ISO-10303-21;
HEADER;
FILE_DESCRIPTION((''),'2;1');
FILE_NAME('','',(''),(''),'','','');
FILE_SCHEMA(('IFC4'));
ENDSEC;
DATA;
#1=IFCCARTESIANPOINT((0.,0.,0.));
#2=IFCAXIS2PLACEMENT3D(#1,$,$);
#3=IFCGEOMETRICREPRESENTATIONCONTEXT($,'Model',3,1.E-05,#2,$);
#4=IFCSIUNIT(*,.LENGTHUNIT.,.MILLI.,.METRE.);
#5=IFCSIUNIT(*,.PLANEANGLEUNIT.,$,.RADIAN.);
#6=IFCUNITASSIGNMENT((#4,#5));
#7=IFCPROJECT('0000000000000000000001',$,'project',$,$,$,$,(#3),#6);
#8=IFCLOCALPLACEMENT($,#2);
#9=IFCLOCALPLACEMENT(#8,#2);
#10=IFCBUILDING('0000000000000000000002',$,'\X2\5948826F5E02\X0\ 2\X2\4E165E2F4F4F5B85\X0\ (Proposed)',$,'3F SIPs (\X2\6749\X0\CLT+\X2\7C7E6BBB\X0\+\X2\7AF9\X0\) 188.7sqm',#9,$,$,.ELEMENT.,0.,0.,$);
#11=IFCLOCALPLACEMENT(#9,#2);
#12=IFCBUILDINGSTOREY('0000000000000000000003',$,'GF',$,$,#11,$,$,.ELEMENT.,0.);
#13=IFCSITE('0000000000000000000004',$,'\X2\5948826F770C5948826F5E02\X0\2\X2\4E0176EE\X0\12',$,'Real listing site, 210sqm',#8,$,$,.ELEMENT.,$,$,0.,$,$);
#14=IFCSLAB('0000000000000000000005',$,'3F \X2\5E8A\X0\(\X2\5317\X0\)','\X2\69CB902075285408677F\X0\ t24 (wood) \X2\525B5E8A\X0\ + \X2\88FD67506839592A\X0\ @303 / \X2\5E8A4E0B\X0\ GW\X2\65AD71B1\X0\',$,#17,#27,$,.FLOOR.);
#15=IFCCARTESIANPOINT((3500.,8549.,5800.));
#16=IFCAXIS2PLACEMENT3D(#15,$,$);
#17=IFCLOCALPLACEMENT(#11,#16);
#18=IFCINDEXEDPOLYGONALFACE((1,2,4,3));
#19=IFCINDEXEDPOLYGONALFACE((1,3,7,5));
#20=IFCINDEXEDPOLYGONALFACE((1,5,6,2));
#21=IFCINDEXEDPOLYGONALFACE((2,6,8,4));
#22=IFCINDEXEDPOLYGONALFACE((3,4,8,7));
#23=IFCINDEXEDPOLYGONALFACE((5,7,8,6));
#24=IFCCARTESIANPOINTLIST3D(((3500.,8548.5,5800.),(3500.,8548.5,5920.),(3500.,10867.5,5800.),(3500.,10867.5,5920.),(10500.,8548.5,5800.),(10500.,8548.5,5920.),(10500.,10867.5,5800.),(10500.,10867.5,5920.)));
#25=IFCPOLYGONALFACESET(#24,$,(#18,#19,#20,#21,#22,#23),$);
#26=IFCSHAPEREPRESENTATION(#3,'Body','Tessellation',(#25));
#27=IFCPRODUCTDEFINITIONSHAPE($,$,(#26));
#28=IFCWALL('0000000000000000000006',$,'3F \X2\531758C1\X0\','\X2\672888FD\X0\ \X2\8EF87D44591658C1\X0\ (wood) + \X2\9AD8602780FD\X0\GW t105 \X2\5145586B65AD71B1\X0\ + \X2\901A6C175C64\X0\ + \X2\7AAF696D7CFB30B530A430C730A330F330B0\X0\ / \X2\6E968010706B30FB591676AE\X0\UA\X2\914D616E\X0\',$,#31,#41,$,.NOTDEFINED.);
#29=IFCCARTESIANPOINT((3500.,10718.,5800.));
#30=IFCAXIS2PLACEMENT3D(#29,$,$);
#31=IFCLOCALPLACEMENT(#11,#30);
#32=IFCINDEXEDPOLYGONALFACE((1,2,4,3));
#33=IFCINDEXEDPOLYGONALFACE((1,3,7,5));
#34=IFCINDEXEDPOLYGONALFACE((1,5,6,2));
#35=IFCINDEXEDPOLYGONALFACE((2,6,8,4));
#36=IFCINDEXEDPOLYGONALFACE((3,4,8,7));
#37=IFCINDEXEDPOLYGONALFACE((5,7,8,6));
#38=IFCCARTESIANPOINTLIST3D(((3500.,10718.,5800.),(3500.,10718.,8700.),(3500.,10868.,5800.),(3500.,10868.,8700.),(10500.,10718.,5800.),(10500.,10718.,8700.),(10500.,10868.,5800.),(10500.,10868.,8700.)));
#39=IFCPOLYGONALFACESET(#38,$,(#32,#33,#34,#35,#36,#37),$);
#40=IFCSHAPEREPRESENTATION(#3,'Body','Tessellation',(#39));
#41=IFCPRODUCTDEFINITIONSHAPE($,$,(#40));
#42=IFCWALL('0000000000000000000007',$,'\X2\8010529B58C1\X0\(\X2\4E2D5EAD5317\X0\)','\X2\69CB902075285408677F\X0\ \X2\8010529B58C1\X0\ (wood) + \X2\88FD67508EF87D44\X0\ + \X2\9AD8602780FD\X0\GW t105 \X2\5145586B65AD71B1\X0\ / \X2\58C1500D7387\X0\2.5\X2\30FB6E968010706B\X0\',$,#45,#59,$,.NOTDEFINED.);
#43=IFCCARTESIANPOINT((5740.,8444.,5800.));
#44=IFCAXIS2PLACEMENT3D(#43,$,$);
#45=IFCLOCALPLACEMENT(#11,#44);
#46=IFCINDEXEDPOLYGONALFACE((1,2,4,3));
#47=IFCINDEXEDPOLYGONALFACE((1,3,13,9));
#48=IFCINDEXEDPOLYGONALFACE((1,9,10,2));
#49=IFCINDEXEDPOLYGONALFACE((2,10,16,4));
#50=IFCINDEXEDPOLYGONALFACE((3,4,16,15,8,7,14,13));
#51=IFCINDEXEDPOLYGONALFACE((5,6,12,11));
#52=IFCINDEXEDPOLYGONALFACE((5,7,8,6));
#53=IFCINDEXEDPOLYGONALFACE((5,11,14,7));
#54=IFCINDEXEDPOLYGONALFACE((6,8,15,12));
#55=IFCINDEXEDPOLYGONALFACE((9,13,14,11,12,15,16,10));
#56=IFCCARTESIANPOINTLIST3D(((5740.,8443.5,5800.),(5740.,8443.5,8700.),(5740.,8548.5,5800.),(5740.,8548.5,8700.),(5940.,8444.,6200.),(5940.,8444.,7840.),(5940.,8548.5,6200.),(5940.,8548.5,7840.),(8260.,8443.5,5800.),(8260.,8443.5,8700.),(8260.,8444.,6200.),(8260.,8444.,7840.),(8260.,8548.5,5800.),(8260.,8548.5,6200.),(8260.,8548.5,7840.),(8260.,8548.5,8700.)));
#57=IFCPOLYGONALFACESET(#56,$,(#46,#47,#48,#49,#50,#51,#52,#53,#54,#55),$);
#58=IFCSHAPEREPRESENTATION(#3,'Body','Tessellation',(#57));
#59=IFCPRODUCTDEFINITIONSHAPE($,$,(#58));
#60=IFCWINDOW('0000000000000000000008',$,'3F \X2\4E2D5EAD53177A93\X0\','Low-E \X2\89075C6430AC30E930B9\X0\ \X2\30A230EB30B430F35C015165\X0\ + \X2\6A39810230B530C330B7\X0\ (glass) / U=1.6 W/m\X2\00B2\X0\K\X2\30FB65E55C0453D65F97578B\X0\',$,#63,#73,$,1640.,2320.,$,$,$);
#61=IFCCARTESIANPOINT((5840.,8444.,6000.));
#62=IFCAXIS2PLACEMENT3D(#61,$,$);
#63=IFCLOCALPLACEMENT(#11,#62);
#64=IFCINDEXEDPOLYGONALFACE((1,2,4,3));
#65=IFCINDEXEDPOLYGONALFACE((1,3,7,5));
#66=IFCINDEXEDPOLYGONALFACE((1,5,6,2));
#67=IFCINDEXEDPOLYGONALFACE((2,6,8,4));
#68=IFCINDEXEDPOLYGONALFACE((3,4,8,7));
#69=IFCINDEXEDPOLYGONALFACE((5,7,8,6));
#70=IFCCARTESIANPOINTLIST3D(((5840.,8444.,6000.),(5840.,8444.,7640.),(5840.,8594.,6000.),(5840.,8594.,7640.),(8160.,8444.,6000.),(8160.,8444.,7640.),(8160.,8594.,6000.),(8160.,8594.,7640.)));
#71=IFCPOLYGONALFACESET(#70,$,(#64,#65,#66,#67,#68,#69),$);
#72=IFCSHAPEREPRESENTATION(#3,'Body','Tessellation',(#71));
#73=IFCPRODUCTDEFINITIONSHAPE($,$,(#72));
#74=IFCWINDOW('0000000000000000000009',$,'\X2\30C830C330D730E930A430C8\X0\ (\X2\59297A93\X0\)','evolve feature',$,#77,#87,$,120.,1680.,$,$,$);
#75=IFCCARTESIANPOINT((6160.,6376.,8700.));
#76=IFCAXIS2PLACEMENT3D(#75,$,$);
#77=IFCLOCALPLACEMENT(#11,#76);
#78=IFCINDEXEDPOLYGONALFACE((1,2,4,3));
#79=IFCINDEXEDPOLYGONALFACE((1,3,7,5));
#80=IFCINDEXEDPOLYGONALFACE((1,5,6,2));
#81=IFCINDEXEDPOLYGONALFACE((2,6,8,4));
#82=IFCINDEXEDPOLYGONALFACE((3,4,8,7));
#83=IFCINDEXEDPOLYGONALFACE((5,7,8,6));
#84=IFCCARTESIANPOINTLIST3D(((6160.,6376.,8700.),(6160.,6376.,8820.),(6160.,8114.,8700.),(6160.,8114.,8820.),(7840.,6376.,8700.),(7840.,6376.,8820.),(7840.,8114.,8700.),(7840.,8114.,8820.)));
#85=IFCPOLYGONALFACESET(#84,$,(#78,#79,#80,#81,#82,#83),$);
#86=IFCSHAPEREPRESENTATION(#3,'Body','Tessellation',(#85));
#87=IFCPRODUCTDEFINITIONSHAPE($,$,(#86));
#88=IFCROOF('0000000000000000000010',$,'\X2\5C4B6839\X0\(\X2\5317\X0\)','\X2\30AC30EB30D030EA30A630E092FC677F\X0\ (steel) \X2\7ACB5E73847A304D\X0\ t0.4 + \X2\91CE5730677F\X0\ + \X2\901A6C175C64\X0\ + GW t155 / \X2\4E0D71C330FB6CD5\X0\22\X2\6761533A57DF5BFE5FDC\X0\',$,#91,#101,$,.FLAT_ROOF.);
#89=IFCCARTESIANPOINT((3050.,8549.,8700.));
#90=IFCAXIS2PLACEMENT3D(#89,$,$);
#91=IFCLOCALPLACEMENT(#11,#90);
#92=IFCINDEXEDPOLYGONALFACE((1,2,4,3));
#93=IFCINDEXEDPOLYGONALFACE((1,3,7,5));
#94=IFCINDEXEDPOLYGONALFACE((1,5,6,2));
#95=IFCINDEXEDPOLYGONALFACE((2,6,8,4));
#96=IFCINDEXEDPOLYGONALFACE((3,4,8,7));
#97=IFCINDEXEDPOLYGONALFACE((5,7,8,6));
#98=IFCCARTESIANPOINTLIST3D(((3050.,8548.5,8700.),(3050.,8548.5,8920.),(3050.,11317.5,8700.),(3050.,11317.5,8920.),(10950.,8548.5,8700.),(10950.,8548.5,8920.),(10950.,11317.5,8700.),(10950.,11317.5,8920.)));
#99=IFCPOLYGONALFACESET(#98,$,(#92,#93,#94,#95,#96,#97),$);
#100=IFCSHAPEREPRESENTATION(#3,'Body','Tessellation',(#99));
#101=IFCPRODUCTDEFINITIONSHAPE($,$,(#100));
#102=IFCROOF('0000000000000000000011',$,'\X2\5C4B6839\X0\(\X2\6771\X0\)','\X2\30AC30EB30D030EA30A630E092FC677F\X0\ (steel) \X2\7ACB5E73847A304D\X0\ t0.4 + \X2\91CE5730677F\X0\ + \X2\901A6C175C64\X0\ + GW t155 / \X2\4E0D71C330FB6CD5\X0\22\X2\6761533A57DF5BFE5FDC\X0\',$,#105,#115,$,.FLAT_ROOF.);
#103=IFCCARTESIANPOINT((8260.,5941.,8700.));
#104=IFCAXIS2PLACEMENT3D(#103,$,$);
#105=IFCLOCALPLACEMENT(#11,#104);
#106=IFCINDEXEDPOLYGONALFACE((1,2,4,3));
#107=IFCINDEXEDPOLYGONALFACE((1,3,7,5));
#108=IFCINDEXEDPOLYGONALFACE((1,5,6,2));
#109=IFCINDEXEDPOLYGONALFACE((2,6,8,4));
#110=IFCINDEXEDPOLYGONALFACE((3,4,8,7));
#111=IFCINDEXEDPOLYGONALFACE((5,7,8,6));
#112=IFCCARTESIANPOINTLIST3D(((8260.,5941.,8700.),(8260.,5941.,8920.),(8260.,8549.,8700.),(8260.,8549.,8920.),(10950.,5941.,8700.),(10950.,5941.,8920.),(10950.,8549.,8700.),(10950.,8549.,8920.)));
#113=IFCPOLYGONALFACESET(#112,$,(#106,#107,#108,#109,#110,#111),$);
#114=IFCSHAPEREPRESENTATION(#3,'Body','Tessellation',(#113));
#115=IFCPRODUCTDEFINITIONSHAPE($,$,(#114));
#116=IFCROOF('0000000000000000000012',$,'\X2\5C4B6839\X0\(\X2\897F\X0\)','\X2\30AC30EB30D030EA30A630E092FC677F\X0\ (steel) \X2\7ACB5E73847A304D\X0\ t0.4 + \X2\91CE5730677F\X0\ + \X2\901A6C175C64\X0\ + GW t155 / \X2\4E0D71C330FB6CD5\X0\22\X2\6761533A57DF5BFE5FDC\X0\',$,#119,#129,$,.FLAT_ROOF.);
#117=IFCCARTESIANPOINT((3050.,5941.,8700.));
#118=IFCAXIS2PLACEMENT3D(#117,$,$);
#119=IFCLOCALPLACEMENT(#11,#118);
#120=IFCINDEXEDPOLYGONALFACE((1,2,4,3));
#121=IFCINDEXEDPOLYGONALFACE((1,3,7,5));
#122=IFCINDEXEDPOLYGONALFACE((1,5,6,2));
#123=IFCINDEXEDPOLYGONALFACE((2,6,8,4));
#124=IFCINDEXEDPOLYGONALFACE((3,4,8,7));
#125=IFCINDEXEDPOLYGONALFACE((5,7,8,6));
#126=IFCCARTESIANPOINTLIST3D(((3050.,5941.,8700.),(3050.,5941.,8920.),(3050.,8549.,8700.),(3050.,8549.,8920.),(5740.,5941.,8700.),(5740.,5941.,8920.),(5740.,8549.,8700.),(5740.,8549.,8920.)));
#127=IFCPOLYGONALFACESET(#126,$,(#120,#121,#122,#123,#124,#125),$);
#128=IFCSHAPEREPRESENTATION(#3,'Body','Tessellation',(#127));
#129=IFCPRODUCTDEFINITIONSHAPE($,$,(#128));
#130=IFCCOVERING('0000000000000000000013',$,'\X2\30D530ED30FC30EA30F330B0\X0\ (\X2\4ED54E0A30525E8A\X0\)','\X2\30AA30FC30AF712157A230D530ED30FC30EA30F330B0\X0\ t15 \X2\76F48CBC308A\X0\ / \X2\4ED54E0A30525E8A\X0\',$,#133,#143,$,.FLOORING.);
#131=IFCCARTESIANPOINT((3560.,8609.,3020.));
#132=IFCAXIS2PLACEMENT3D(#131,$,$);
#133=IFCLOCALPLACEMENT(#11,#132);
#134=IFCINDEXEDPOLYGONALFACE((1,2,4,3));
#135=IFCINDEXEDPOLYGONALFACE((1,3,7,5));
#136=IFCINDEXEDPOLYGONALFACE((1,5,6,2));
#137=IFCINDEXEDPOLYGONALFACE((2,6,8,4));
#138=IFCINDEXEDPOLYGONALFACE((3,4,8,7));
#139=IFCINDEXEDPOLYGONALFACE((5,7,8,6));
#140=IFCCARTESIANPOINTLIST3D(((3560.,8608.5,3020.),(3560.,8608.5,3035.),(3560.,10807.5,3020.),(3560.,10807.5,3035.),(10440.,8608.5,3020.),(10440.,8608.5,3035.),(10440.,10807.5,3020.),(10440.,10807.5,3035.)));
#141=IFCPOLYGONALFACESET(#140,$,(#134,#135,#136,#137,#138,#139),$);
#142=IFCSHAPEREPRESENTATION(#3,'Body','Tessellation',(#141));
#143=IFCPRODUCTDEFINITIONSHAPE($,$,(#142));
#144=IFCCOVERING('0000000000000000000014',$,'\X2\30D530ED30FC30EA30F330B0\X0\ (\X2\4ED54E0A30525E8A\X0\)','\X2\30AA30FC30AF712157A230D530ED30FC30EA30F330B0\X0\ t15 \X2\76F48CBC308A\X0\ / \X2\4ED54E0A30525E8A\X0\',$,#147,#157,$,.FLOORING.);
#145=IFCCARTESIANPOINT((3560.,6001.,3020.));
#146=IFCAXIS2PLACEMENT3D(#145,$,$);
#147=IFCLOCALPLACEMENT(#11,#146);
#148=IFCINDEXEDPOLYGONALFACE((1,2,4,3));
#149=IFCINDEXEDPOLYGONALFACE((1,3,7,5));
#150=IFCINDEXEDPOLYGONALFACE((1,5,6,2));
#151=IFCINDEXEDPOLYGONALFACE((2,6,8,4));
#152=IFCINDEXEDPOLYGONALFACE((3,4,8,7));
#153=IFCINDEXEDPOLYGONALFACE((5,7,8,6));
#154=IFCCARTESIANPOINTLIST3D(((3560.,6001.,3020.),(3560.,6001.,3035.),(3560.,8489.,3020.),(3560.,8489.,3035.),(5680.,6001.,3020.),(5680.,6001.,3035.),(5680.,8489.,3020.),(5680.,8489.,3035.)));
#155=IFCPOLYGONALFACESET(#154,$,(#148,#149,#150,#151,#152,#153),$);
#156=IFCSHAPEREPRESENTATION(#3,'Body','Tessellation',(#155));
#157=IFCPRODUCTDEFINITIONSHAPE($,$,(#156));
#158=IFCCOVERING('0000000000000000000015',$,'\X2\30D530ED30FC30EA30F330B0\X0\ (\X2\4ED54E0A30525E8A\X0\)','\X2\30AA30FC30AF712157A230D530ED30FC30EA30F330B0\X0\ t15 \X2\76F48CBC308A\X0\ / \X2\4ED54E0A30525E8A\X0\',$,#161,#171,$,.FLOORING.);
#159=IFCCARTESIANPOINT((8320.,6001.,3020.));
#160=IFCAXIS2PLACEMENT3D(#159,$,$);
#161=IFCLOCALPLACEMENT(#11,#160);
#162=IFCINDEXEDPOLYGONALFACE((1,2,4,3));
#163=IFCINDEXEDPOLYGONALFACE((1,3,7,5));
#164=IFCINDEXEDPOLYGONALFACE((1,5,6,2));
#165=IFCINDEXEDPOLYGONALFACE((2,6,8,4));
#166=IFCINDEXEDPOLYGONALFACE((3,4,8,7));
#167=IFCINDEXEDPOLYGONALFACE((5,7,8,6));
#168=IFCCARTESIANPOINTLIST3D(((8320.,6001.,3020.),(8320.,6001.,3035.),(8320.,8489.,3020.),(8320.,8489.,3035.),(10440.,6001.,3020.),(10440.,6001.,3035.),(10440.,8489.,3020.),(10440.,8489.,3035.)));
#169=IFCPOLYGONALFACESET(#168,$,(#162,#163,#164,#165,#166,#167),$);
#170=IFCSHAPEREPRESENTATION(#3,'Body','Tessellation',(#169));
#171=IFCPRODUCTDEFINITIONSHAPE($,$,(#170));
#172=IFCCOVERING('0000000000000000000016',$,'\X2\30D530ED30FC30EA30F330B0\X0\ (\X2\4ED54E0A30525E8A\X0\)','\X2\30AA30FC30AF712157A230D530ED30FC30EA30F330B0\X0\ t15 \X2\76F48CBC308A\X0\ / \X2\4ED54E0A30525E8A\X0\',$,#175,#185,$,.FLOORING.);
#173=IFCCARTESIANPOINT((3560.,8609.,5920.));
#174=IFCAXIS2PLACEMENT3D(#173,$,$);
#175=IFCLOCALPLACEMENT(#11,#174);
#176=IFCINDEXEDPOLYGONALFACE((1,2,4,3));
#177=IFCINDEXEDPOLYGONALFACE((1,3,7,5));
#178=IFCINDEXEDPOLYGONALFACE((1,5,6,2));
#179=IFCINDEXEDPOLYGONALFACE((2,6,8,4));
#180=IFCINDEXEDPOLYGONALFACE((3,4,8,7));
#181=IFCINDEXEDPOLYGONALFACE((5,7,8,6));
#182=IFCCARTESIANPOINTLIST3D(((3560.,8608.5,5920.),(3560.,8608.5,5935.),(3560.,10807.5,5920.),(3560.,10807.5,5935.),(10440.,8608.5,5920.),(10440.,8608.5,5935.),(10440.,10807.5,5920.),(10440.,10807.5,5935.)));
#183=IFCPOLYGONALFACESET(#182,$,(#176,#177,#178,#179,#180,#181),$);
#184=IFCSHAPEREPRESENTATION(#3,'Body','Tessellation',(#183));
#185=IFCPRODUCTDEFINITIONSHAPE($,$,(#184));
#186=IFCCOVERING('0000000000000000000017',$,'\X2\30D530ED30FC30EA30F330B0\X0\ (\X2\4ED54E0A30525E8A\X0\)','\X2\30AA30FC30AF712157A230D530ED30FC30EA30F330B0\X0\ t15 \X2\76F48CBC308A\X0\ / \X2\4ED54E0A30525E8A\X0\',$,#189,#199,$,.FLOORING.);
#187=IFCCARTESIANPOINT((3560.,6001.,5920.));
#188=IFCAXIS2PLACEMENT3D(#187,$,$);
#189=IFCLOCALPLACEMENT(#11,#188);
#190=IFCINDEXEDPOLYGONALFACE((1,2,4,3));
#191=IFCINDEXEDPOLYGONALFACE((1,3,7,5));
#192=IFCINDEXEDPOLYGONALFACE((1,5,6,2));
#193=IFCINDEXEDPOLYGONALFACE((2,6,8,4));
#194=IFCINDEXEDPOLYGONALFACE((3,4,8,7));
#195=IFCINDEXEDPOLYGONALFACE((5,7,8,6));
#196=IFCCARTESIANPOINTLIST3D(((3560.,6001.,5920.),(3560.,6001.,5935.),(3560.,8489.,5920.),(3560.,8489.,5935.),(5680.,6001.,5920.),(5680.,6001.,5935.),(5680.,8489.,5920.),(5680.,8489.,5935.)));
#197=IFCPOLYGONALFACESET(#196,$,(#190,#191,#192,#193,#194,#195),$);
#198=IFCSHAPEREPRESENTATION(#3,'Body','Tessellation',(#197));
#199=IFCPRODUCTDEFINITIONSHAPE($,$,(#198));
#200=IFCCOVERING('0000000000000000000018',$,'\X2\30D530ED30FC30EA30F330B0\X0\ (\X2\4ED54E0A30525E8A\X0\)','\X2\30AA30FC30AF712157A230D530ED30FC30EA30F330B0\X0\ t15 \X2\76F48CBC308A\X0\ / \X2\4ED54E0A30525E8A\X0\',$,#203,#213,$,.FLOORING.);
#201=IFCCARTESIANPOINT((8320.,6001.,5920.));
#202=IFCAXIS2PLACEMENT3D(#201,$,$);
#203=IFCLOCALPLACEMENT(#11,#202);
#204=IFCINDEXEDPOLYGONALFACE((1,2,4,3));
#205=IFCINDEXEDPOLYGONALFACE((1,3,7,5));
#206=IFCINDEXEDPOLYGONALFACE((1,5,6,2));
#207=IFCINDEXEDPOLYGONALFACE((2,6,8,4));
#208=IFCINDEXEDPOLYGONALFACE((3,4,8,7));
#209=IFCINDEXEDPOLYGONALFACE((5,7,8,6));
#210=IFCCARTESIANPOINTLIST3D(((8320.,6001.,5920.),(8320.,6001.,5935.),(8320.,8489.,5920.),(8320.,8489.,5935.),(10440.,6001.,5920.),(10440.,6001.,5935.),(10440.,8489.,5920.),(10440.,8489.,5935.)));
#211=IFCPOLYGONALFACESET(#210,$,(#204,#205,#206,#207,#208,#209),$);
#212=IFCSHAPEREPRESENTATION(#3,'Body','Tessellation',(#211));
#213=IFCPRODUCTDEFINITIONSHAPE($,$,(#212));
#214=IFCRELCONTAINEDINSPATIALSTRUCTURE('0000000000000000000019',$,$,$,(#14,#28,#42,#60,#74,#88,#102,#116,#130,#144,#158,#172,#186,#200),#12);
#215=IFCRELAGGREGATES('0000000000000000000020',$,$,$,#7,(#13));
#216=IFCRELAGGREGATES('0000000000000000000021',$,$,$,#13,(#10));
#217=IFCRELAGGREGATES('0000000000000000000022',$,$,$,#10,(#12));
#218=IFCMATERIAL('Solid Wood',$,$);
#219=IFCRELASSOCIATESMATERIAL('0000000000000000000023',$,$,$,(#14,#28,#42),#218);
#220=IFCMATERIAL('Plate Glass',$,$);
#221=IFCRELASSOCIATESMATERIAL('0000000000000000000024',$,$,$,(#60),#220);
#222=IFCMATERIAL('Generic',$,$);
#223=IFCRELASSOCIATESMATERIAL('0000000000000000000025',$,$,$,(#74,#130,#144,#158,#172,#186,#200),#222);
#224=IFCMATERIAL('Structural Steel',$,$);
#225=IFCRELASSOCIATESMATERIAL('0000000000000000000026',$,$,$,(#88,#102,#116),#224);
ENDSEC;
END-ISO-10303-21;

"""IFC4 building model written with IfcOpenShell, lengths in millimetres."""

from ifc_helpers import new_model, si_unit, frame, frame_2d, origin, place, context, project, spatial, rectangle, extrude, material, element, fill, save


model = new_model("IFC4")

# Units and contexts
model_context = context("Model", 3, precision=1e-05, world=origin())
ifc_project = project(units=[si_unit("LENGTHUNIT", "METRE", prefix="MILLI"), si_unit("PLANEANGLEUNIT", "RADIAN")], contexts=[model_context])

# Site, building, storey
site_placement = place(None, origin())
site = spatial("IfcSite", under=ifc_project, at=site_placement, Name="奈良県奈良市2丁目12", ObjectType="Real listing site, 210sqm", CompositionType="ELEMENT", RefElevation=0.0)
building_placement = place(site_placement, origin())
building = spatial("IfcBuilding", under=site, at=building_placement, Name="奈良市 2世帯住宅 (Proposed)", ObjectType="3F SIPs (杉CLT+籾殻+竹) 188.7sqm", CompositionType="ELEMENT", ElevationOfRefHeight=0.0, ElevationOfTerrain=0.0)
storey_placement = place(building_placement, origin())
storey = spatial("IfcBuildingStorey", under=building, at=storey_placement, Name="GF", CompositionType="ELEMENT", Elevation=0.0)

# Slab
ifc_material_1 = material(Name="Solid Wood")
slab_placement = place(storey_placement, frame((3500.0, 8549.0, 5800.0)))
element("IfcSlab", 1, at=slab_placement, inside=storey, material=ifc_material_1, Name="3F 床(北)", Description="構造用合板 t24 (wood) 剛床 + 製材根太 @303 / 床下 GW断熱", PredefinedType="FLOOR", context=model_context, shape_type="SweptSolid", body=[
    extrude(rectangle(XDim=7000.0, YDim=2319.0, at=frame_2d((3500.0, 1159.0))), frame((3500.0, 8549.0, 5800.0)), (0.0, 0.0, 1.0), 120.0),
])

# Wall
wall_1_placement = place(storey_placement, frame((3500.0, 10718.0, 5800.0)))
element("IfcWall", 2, at=wall_1_placement, inside=storey, material=ifc_material_1, Name="3F 北壁", Description="木製 軸組外壁 (wood) + 高性能GW t105 充填断熱 + 通気層 + 窯業系サイディング / 準耐火・外皮UA配慮", PredefinedType="NOTDEFINED", context=model_context, shape_type="SweptSolid", body=[
    extrude(rectangle(XDim=7000.0, YDim=150.0, at=frame_2d((3500.0, 75.0))), frame((3500.0, 10718.0, 5800.0)), (0.0, 0.0, 1.0), 2900.0),
])

# Wall, opening, window
wall_2_placement = place(storey_placement, frame((5740.0, 8444.0, 5800.0)))
wall_2 = element("IfcWall", 3, at=wall_2_placement, inside=storey, material=ifc_material_1, Name="耐力壁(中庭北)", Description="構造用合板 耐力壁 (wood) + 製材軸組 + 高性能GW t105 充填断熱 / 壁倍率2.5・準耐火", PredefinedType="NOTDEFINED", context=model_context, shape_type="SweptSolid", body=[
    extrude(rectangle(XDim=2520.0, YDim=105.0, at=frame_2d((1260.0, 52.0))), frame((5740.0, 8444.0, 5800.0)), (0.0, 0.0, 1.0), 2900.0),
])
opening_placement = place(storey_placement, frame((5840.0, 8444.0, 6000.0)))
opening = element("IfcOpeningElement", 4, at=opening_placement, cuts=wall_2, PredefinedType="NOTDEFINED", context=model_context, shape_type="SweptSolid", body=[
    extrude(rectangle(XDim=2320.0, YDim=150.0, at=frame_2d((1160.0, 75.0))), frame((5840.0, 8444.0, 6000.0)), (0.0, 0.0, 1.0), 1640.0),
])
ifc_material_2 = material(Name="Plate Glass")
window_1_placement = place(storey_placement, frame((5840.0, 8444.0, 6000.0)))
window_1 = element("IfcWindow", 5, at=window_1_placement, inside=storey, material=ifc_material_2, Name="3F 中庭北窓", Description="Low-E 複層ガラス アルゴン封入 + 樹脂サッシ (glass) / U=1.6 W/m²K・日射取得型", OverallHeight=1640.0, OverallWidth=2320.0, context=model_context, shape_type="SweptSolid", body=[
    extrude(rectangle(XDim=2320.0, YDim=150.0, at=frame_2d((1160.0, 75.0))), frame((5840.0, 8444.0, 6000.0)), (0.0, 0.0, 1.0), 1640.0),
])
fill(opening, window_1)

# Window
ifc_material_3 = material(Name="Generic")
window_2_placement = place(storey_placement, frame((6160.0, 6376.0, 8700.0)))
element("IfcWindow", 6, at=window_2_placement, inside=storey, material=ifc_material_3, Name="トップライト (天窓)", Description="evolve feature", OverallHeight=120.0, OverallWidth=1680.0, context=model_context, shape_type="SweptSolid", body=[
    extrude(rectangle(XDim=1680.0, YDim=1738.0, at=frame_2d((840.0, 869.0))), frame((6160.0, 6376.0, 8700.0)), (0.0, 0.0, 1.0), 120.0),
])

# Roofs
ifc_material_4 = material(Name="Structural Steel")
roof_1_placement = place(storey_placement, frame((3050.0, 8549.0, 8700.0)))
element("IfcRoof", 7, at=roof_1_placement, inside=storey, material=ifc_material_4, Name="屋根(北)", Description="ガルバリウム鋼板 (steel) 立平葺き t0.4 + 野地板 + 通気層 + GW t155 / 不燃・法22条区域対応", PredefinedType="FLAT_ROOF", context=model_context, shape_type="SweptSolid", body=[
    extrude(rectangle(XDim=7900.0, YDim=2769.0, at=frame_2d((3950.0, 1384.0))), frame((3050.0, 8549.0, 8700.0)), (0.0, 0.0, 1.0), 220.0),
])
roof_2_placement = place(storey_placement, frame((8260.0, 5941.0, 8700.0)))
element("IfcRoof", 8, at=roof_2_placement, inside=storey, material=ifc_material_4, Name="屋根(東)", Description="ガルバリウム鋼板 (steel) 立平葺き t0.4 + 野地板 + 通気層 + GW t155 / 不燃・法22条区域対応", PredefinedType="FLAT_ROOF", context=model_context, shape_type="SweptSolid", body=[
    extrude(rectangle(XDim=2690.0, YDim=2608.0, at=frame_2d((1345.0, 1304.0))), frame((8260.0, 5941.0, 8700.0)), (0.0, 0.0, 1.0), 220.0),
])
roof_3_placement = place(storey_placement, frame((3050.0, 5941.0, 8700.0)))
element("IfcRoof", 9, at=roof_3_placement, inside=storey, material=ifc_material_4, Name="屋根(西)", Description="ガルバリウム鋼板 (steel) 立平葺き t0.4 + 野地板 + 通気層 + GW t155 / 不燃・法22条区域対応", PredefinedType="FLAT_ROOF", context=model_context, shape_type="SweptSolid", body=[
    extrude(rectangle(XDim=2690.0, YDim=2608.0, at=frame_2d((1345.0, 1304.0))), frame((3050.0, 5941.0, 8700.0)), (0.0, 0.0, 1.0), 220.0),
])

# Coverings
covering_1_placement = place(storey_placement, frame((3560.0, 8609.0, 3020.0)))
element("IfcCovering", 10, at=covering_1_placement, inside=storey, material=ifc_material_3, Name="フローリング (仕上げ床)", Description="オーク無垢フローリング t15 直貼り / 仕上げ床", PredefinedType="FLOORING", context=model_context, shape_type="SweptSolid", body=[
    extrude(rectangle(XDim=6880.0, YDim=2199.0, at=frame_2d((3440.0, 1099.0))), frame((3560.0, 8609.0, 3020.0)), (0.0, 0.0, 1.0), 15.0),
])
covering_2_placement = place(storey_placement, frame((3560.0, 6001.0, 3020.0)))
element("IfcCovering", 11, at=covering_2_placement, inside=storey, material=ifc_material_3, Name="フローリング (仕上げ床)", Description="オーク無垢フローリング t15 直貼り / 仕上げ床", PredefinedType="FLOORING", context=model_context, shape_type="SweptSolid", body=[
    extrude(rectangle(XDim=2120.0, YDim=2488.0, at=frame_2d((1060.0, 1244.0))), frame((3560.0, 6001.0, 3020.0)), (0.0, 0.0, 1.0), 15.0),
])
covering_3_placement = place(storey_placement, frame((8320.0, 6001.0, 3020.0)))
element("IfcCovering", 12, at=covering_3_placement, inside=storey, material=ifc_material_3, Name="フローリング (仕上げ床)", Description="オーク無垢フローリング t15 直貼り / 仕上げ床", PredefinedType="FLOORING", context=model_context, shape_type="SweptSolid", body=[
    extrude(rectangle(XDim=2120.0, YDim=2488.0, at=frame_2d((1060.0, 1244.0))), frame((8320.0, 6001.0, 3020.0)), (0.0, 0.0, 1.0), 15.0),
])
covering_4_placement = place(storey_placement, frame((3560.0, 8609.0, 5920.0)))
element("IfcCovering", 13, at=covering_4_placement, inside=storey, material=ifc_material_3, Name="フローリング (仕上げ床)", Description="オーク無垢フローリング t15 直貼り / 仕上げ床", PredefinedType="FLOORING", context=model_context, shape_type="SweptSolid", body=[
    extrude(rectangle(XDim=6880.0, YDim=2199.0, at=frame_2d((3440.0, 1099.0))), frame((3560.0, 8609.0, 5920.0)), (0.0, 0.0, 1.0), 15.0),
])
covering_5_placement = place(storey_placement, frame((3560.0, 6001.0, 5920.0)))
element("IfcCovering", 14, at=covering_5_placement, inside=storey, material=ifc_material_3, Name="フローリング (仕上げ床)", Description="オーク無垢フローリング t15 直貼り / 仕上げ床", PredefinedType="FLOORING", context=model_context, shape_type="SweptSolid", body=[
    extrude(rectangle(XDim=2120.0, YDim=2488.0, at=frame_2d((1060.0, 1244.0))), frame((3560.0, 6001.0, 5920.0)), (0.0, 0.0, 1.0), 15.0),
])
covering_6_placement = place(storey_placement, frame((8320.0, 6001.0, 5920.0)))
element("IfcCovering", 15, at=covering_6_placement, inside=storey, material=ifc_material_3, Name="フローリング (仕上げ床)", Description="オーク無垢フローリング t15 直貼り / 仕上げ床", PredefinedType="FLOORING", context=model_context, shape_type="SweptSolid", body=[
    extrude(rectangle(XDim=2120.0, YDim=2488.0, at=frame_2d((1060.0, 1244.0))), frame((8320.0, 6001.0, 5920.0)), (0.0, 0.0, 1.0), 15.0),
])

save(model, "model.ifc")
